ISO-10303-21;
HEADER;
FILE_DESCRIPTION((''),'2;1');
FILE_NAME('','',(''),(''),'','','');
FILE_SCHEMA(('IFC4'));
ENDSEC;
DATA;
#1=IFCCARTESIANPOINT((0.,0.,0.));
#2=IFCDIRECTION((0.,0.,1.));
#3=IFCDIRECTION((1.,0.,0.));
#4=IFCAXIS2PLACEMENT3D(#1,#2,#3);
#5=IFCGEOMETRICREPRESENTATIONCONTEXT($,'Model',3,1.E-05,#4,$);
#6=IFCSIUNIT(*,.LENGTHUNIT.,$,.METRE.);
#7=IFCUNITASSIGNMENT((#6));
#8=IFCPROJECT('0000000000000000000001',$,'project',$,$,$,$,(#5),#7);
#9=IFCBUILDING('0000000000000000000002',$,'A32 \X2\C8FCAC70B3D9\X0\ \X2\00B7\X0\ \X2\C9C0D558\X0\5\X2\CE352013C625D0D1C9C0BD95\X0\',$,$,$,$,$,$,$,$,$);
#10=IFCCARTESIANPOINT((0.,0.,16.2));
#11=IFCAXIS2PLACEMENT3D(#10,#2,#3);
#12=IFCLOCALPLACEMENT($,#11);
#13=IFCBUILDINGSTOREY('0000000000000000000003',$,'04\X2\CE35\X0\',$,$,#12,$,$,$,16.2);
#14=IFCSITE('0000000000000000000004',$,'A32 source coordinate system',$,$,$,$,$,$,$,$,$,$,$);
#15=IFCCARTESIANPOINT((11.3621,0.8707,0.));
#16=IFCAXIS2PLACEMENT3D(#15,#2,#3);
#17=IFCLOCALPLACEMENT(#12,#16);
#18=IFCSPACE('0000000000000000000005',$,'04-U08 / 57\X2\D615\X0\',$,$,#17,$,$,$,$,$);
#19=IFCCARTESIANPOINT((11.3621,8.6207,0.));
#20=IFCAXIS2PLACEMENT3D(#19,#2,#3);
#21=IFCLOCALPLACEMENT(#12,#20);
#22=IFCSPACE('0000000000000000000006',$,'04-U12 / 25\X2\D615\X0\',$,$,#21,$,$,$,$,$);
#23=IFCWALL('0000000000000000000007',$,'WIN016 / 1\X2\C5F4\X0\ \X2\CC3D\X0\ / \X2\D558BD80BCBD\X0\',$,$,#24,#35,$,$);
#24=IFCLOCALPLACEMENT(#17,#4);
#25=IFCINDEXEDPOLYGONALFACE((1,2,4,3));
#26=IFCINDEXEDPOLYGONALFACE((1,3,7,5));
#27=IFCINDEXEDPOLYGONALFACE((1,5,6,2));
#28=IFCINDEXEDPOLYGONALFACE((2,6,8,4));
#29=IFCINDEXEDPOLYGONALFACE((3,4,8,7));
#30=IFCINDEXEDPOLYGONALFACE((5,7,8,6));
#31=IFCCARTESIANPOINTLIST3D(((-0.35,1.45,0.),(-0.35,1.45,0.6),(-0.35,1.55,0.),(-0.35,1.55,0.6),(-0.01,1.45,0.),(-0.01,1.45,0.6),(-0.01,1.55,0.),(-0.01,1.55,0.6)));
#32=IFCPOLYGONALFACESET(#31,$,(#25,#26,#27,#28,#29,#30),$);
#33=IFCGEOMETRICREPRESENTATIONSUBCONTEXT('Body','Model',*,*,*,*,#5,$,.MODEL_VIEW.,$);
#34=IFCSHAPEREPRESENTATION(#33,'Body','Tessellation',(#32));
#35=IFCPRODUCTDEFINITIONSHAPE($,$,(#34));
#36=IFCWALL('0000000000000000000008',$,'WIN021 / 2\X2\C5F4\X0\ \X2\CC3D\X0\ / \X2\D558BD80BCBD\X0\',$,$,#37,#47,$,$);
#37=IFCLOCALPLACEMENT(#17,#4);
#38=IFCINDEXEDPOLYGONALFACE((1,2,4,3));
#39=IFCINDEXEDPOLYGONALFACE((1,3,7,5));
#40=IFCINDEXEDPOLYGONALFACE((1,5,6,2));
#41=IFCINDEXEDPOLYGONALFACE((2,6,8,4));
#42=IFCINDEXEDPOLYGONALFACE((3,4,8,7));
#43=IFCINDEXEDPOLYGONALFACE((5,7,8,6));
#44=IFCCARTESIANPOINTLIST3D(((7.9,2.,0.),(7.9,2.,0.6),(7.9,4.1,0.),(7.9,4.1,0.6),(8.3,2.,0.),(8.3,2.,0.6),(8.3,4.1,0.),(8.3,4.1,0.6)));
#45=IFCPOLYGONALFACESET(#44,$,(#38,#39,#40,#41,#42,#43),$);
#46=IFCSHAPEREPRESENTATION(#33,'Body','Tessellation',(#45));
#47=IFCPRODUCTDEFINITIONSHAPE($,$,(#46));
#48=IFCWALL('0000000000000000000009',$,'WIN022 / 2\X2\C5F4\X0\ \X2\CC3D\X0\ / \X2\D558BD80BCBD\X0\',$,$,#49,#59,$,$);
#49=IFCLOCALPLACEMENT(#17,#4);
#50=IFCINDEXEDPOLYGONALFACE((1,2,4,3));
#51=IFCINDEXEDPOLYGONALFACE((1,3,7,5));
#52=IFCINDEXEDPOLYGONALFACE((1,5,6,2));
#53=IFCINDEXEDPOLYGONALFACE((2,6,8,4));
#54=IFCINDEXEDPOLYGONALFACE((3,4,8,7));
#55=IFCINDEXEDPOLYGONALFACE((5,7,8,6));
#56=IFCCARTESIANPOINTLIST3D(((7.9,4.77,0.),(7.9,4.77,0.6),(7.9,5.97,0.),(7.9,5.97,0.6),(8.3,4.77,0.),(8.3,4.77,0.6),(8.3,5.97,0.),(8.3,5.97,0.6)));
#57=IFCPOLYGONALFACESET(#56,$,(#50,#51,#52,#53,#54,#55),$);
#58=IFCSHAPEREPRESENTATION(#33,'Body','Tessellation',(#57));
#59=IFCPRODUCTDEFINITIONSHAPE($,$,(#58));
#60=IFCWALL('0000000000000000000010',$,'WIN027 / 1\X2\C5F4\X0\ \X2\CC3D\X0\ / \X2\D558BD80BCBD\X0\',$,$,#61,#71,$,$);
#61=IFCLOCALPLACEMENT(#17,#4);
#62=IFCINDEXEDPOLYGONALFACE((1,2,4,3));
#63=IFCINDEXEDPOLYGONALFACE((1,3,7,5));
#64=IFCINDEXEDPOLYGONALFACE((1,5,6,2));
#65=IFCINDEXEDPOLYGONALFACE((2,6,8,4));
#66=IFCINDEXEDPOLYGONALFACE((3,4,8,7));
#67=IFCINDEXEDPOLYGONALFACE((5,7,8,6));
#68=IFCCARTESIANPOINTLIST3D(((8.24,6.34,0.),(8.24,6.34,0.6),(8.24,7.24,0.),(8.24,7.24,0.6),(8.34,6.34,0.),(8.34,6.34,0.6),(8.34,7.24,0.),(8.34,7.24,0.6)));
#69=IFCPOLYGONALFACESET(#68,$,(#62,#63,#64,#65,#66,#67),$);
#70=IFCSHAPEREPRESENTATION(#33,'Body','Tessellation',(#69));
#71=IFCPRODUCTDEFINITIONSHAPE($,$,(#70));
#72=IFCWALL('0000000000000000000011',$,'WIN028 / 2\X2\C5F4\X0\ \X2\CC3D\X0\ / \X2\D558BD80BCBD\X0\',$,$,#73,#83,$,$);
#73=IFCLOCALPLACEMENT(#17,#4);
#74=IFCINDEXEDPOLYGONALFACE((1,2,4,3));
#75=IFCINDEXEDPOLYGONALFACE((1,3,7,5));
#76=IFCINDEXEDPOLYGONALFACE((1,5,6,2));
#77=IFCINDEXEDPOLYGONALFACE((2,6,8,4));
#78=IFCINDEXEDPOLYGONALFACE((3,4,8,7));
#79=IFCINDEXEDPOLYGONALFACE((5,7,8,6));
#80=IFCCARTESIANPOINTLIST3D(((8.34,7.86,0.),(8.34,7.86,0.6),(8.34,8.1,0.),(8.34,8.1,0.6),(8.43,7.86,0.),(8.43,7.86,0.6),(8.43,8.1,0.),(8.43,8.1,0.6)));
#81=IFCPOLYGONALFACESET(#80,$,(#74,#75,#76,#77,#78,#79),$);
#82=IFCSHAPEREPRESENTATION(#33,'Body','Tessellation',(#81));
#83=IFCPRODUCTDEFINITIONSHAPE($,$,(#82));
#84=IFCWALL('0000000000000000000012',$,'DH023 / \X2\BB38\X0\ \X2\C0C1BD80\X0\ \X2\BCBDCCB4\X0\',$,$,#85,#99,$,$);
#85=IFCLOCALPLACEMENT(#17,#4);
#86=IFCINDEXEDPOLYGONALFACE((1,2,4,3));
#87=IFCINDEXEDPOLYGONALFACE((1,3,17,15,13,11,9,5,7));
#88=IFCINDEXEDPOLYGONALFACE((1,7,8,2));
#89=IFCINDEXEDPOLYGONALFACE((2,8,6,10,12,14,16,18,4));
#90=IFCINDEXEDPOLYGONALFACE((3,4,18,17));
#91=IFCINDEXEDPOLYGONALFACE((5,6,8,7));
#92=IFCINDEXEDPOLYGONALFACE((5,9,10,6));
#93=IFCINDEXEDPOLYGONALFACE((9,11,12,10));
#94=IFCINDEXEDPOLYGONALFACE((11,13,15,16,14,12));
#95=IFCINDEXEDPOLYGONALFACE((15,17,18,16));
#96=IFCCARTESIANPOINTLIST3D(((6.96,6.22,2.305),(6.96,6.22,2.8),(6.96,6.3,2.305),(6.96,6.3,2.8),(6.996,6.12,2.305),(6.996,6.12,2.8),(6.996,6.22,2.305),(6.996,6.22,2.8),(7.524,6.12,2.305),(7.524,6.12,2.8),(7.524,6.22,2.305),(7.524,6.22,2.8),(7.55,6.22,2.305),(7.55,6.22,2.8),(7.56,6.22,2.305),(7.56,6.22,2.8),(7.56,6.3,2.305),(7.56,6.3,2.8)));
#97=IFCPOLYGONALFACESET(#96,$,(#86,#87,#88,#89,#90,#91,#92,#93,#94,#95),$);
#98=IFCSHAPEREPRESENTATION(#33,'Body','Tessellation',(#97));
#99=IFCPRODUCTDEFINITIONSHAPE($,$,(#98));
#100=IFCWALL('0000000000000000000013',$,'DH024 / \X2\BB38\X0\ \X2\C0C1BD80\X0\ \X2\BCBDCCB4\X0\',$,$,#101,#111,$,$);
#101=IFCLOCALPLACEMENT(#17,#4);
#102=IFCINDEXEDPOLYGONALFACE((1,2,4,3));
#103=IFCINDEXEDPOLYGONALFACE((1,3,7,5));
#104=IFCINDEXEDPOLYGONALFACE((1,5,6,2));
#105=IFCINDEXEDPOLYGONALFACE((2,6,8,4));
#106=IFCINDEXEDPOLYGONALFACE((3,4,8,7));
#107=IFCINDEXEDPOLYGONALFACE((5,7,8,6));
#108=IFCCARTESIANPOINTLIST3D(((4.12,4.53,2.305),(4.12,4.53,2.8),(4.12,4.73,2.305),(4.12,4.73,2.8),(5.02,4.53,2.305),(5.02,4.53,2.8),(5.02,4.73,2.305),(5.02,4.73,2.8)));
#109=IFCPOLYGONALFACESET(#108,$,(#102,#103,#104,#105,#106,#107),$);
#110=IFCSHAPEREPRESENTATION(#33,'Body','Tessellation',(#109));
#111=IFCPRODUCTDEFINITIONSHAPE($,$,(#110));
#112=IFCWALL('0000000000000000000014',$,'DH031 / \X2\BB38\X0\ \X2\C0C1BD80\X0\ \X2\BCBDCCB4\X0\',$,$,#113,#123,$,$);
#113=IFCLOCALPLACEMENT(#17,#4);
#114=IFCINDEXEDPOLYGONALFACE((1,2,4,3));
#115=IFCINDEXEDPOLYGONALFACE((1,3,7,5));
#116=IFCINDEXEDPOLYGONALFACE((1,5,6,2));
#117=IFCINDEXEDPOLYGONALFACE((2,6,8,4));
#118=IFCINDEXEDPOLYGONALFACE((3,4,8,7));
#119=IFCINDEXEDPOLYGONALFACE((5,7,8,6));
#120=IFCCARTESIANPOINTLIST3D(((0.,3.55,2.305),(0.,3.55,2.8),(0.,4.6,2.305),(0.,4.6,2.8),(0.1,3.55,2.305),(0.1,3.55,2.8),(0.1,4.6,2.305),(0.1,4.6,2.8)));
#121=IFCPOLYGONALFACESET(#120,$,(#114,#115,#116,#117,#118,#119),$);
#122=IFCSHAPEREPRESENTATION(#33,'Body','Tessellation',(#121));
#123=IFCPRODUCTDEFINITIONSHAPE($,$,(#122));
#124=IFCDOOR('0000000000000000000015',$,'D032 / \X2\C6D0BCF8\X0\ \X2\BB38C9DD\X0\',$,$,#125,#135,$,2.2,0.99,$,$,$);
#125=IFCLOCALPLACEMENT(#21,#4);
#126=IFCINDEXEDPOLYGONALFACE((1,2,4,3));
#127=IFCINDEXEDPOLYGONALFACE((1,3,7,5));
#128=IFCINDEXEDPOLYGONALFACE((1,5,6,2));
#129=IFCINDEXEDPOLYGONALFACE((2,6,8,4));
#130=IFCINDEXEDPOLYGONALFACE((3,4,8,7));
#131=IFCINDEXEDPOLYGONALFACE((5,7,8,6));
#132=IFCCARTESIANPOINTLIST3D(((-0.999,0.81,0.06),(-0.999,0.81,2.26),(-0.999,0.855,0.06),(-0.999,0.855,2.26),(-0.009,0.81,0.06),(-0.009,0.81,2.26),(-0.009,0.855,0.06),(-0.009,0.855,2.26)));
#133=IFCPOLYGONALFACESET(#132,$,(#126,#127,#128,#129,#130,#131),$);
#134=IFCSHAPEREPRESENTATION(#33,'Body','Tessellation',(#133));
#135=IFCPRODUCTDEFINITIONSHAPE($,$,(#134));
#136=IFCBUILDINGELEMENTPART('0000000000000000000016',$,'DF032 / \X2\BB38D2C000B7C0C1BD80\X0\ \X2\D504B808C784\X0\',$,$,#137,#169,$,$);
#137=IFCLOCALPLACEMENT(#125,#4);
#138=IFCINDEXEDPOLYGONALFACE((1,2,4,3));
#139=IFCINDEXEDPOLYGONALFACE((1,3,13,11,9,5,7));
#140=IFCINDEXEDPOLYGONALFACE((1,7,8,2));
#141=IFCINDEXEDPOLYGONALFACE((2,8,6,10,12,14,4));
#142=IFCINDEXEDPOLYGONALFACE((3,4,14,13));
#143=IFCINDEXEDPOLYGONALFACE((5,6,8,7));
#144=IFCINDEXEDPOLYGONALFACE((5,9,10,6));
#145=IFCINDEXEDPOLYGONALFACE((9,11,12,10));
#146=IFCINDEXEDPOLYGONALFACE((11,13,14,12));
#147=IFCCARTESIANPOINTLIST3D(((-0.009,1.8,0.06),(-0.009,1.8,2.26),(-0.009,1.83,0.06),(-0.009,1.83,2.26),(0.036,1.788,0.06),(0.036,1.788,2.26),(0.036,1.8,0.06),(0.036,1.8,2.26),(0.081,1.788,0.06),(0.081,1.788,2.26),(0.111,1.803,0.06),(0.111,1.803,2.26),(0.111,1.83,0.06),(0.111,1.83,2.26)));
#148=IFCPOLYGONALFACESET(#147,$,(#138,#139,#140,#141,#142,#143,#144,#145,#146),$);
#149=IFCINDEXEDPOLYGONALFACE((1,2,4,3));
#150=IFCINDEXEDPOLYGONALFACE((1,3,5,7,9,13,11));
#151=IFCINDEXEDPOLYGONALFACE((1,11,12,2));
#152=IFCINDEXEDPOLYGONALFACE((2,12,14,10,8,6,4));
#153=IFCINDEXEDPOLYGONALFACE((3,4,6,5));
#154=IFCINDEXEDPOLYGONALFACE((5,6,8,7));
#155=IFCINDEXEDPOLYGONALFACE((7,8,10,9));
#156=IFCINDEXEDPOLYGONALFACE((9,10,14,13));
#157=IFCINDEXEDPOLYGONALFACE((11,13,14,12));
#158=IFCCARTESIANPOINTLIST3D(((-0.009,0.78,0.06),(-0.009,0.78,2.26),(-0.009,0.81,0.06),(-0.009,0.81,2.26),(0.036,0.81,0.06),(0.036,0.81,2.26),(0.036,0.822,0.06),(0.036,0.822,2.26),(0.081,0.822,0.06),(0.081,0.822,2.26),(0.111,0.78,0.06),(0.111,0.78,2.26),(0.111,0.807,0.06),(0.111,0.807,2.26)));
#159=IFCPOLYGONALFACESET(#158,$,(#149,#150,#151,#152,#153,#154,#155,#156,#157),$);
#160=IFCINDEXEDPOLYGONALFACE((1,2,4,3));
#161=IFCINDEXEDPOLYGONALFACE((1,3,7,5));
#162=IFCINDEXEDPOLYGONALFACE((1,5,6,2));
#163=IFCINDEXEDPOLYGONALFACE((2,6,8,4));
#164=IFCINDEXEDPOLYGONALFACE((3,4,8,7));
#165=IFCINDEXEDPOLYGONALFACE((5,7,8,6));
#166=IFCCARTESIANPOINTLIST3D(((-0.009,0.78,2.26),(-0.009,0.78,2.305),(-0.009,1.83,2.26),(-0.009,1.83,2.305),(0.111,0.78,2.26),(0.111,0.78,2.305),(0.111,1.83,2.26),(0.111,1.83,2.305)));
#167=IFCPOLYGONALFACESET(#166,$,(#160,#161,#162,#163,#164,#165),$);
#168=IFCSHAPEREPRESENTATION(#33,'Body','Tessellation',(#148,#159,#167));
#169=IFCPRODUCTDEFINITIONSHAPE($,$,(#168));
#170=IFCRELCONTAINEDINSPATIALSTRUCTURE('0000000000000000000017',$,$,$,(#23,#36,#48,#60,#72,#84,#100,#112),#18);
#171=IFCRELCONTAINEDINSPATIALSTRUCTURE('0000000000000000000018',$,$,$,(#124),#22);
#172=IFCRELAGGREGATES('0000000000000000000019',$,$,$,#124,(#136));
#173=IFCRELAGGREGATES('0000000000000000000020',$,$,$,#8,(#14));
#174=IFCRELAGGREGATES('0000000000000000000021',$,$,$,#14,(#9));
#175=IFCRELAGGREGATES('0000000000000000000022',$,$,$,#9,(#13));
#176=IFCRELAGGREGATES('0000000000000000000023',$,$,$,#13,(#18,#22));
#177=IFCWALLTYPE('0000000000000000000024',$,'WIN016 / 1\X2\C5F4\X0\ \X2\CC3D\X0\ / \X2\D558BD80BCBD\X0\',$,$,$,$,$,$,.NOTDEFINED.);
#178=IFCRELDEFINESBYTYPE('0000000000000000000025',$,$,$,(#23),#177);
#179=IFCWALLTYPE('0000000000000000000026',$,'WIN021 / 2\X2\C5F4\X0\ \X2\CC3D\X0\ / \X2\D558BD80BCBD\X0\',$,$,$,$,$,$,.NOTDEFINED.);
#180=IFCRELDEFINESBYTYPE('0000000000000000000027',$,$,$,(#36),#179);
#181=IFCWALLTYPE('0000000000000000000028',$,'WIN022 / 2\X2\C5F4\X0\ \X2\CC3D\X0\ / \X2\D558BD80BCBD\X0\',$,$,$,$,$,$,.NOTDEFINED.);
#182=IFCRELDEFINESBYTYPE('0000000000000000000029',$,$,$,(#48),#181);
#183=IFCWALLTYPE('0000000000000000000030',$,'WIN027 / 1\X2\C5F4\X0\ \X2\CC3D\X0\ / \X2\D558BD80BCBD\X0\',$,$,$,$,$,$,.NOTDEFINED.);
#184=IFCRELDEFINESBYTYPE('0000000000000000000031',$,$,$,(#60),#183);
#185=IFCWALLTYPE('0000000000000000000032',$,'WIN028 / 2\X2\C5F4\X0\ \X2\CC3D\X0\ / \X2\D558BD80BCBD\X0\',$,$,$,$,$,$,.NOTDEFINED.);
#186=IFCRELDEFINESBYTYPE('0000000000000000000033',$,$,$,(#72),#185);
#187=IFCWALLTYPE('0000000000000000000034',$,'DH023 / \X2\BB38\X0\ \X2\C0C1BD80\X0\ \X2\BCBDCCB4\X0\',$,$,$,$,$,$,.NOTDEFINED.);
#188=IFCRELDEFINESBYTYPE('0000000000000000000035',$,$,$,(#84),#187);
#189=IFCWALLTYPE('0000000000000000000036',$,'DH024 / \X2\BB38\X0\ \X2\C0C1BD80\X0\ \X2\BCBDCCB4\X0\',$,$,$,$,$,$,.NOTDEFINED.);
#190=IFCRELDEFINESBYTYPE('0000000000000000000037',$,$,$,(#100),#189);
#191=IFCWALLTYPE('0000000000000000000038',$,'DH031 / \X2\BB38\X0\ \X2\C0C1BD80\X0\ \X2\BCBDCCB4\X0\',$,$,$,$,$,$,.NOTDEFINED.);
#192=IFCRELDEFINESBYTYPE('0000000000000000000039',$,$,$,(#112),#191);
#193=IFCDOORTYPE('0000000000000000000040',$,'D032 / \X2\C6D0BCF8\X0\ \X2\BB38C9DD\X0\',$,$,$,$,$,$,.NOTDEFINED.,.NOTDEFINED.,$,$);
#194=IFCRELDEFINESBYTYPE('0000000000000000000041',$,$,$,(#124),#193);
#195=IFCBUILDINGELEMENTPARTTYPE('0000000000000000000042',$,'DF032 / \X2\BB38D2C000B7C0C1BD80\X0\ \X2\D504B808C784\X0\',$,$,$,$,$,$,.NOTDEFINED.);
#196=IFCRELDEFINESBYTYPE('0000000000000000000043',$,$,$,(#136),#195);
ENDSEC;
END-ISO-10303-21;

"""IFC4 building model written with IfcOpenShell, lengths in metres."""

from ifc_helpers import new_model, si_unit, frame, origin, origin_with_axes, place, context, subcontext, project, spatial, polyline, outline, extrude, source, transform, mapped, type_object, type_shapes, element, aggregate, save


model = new_model("IFC4")

# Units and contexts
model_context = context("Model", 3, precision=1e-05, world=origin_with_axes())
body_context = subcontext(model_context, "Body", "Model", "MODEL_VIEW")
ifc_project = project(units=[si_unit("LENGTHUNIT", "METRE")], contexts=[model_context])

# Site, building, storey, space
site = spatial("IfcSite", under=ifc_project, Name="A32 source coordinate system")
building = spatial("IfcBuilding", under=site, Name="A32 주거동 · 지하5층–옥탑지붕")
storey_placement = place(None, frame((0.0, 0.0, 16.2), z_axis=(0.0, 0.0, 1.0), x_axis=(1.0, 0.0, 0.0)))
storey = spatial("IfcBuildingStorey", under=building, at=storey_placement, Name="04층", Elevation=16.2)
space_1_placement = place(storey_placement, frame((11.3621, 0.8707, 0.0), z_axis=(0.0, 0.0, 1.0), x_axis=(1.0, 0.0, 0.0)))
space_1 = spatial("IfcSpace", under=storey, at=space_1_placement, Name="04-U08 / 57형")

# Walls
wall_type_1 = type_object("IfcWallType", Name="WIN016 / 1열 창 / 하부벽", PredefinedType="NOTDEFINED")
shared_shape_1 = source(origin(), body_context, "Body", "SweptSolid", [
    extrude(outline(polyline([(-0.35, 1.45), (-0.35, 1.55), (-0.01, 1.55), (-0.01, 1.45), (-0.35, 1.45)])), origin(), (0.0, 0.0, 1.0), 0.6),
])
type_shapes(wall_type_1, [shared_shape_1])
wall_1_placement = place(space_1_placement, origin_with_axes())
element("IfcWall", 1, at=wall_1_placement, inside=space_1, type_object=wall_type_1, Name="WIN016 / 1열 창 / 하부벽", context=body_context, shape_type="MappedRepresentation", body=[
    mapped(shared_shape_1, transform((0.0, 0.0, 0.0), scale=1.0)),
])
wall_type_2 = type_object("IfcWallType", Name="WIN021 / 2열 창 / 하부벽", PredefinedType="NOTDEFINED")
shared_shape_2 = source(origin(), body_context, "Body", "SweptSolid", [
    extrude(outline(polyline([(7.9, 2.0), (7.9, 4.1), (8.3, 4.1), (8.3, 2.0), (7.9, 2.0)])), origin(), (0.0, 0.0, 1.0), 0.6),
])
type_shapes(wall_type_2, [shared_shape_2])
wall_2_placement = place(space_1_placement, origin_with_axes())
element("IfcWall", 2, at=wall_2_placement, inside=space_1, type_object=wall_type_2, Name="WIN021 / 2열 창 / 하부벽", context=body_context, shape_type="MappedRepresentation", body=[
    mapped(shared_shape_2, transform((0.0, 0.0, 0.0), scale=1.0)),
])
wall_type_3 = type_object("IfcWallType", Name="WIN022 / 2열 창 / 하부벽", PredefinedType="NOTDEFINED")
shared_shape_3 = source(origin(), body_context, "Body", "SweptSolid", [
    extrude(outline(polyline([(7.9, 4.77), (7.9, 5.97), (8.3, 5.97), (8.3, 4.77), (7.9, 4.77)])), origin(), (0.0, 0.0, 1.0), 0.6),
])
type_shapes(wall_type_3, [shared_shape_3])
wall_3_placement = place(space_1_placement, origin_with_axes())
element("IfcWall", 3, at=wall_3_placement, inside=space_1, type_object=wall_type_3, Name="WIN022 / 2열 창 / 하부벽", context=body_context, shape_type="MappedRepresentation", body=[
    mapped(shared_shape_3, transform((0.0, 0.0, 0.0), scale=1.0)),
])
wall_type_4 = type_object("IfcWallType", Name="WIN027 / 1열 창 / 하부벽", PredefinedType="NOTDEFINED")
shared_shape_4 = source(origin(), body_context, "Body", "SweptSolid", [
    extrude(outline(polyline([(8.24, 6.34), (8.24, 7.24), (8.34, 7.24), (8.34, 6.34), (8.24, 6.34)])), origin(), (0.0, 0.0, 1.0), 0.6),
])
type_shapes(wall_type_4, [shared_shape_4])
wall_4_placement = place(space_1_placement, origin_with_axes())
element("IfcWall", 4, at=wall_4_placement, inside=space_1, type_object=wall_type_4, Name="WIN027 / 1열 창 / 하부벽", context=body_context, shape_type="MappedRepresentation", body=[
    mapped(shared_shape_4, transform((0.0, 0.0, 0.0), scale=1.0)),
])
wall_type_5 = type_object("IfcWallType", Name="WIN028 / 2열 창 / 하부벽", PredefinedType="NOTDEFINED")
shared_shape_5 = source(origin(), body_context, "Body", "SweptSolid", [
    extrude(outline(polyline([(8.34, 7.86), (8.34, 8.1), (8.43, 8.1), (8.43, 7.86), (8.34, 7.86)])), origin(), (0.0, 0.0, 1.0), 0.6),
])
type_shapes(wall_type_5, [shared_shape_5])
wall_5_placement = place(space_1_placement, origin_with_axes())
element("IfcWall", 5, at=wall_5_placement, inside=space_1, type_object=wall_type_5, Name="WIN028 / 2열 창 / 하부벽", context=body_context, shape_type="MappedRepresentation", body=[
    mapped(shared_shape_5, transform((0.0, 0.0, 0.0), scale=1.0)),
])
wall_type_6 = type_object("IfcWallType", Name="DH023 / 문 상부 벽체", PredefinedType="NOTDEFINED")
shared_shape_6 = source(origin(), body_context, "Body", "SweptSolid", [
    extrude(outline(polyline([(6.96, 6.3), (7.56, 6.3), (7.56, 6.22), (7.55, 6.22), (7.524, 6.22), (7.524, 6.12), (6.996, 6.12), (6.996, 6.22), (6.96, 6.22), (6.96, 6.3)])), frame((0.0, 0.0, 2.305)), (0.0, 0.0, 1.0), 0.495),
])
type_shapes(wall_type_6, [shared_shape_6])
wall_6_placement = place(space_1_placement, origin_with_axes())
element("IfcWall", 6, at=wall_6_placement, inside=space_1, type_object=wall_type_6, Name="DH023 / 문 상부 벽체", context=body_context, shape_type="MappedRepresentation", body=[
    mapped(shared_shape_6, transform((0.0, 0.0, 0.0), scale=1.0)),
])
wall_type_7 = type_object("IfcWallType", Name="DH024 / 문 상부 벽체", PredefinedType="NOTDEFINED")
shared_shape_7 = source(origin(), body_context, "Body", "SweptSolid", [
    extrude(outline(polyline([(4.12, 4.73), (5.02, 4.73), (5.02, 4.53), (4.12, 4.53), (4.12, 4.73)])), frame((0.0, 0.0, 2.305)), (0.0, 0.0, 1.0), 0.495),
])
type_shapes(wall_type_7, [shared_shape_7])
wall_7_placement = place(space_1_placement, origin_with_axes())
element("IfcWall", 7, at=wall_7_placement, inside=space_1, type_object=wall_type_7, Name="DH024 / 문 상부 벽체", context=body_context, shape_type="MappedRepresentation", body=[
    mapped(shared_shape_7, transform((0.0, 0.0, 0.0), scale=1.0)),
])
wall_type_8 = type_object("IfcWallType", Name="DH031 / 문 상부 벽체", PredefinedType="NOTDEFINED")
shared_shape_8 = source(origin(), body_context, "Body", "SweptSolid", [
    extrude(outline(polyline([(0.0, 4.6), (0.1, 4.6), (0.1, 3.55), (0.0, 3.55), (0.0, 4.6)])), frame((0.0, 0.0, 2.305)), (0.0, 0.0, 1.0), 0.495),
])
type_shapes(wall_type_8, [shared_shape_8])
wall_8_placement = place(space_1_placement, origin_with_axes())
element("IfcWall", 8, at=wall_8_placement, inside=space_1, type_object=wall_type_8, Name="DH031 / 문 상부 벽체", context=body_context, shape_type="MappedRepresentation", body=[
    mapped(shared_shape_8, transform((0.0, 0.0, 0.0), scale=1.0)),
])

# Shared definitions
space_2_placement = place(storey_placement, frame((11.3621, 8.6207, 0.0), z_axis=(0.0, 0.0, 1.0), x_axis=(1.0, 0.0, 0.0)))
space_2 = spatial("IfcSpace", under=storey, at=space_2_placement, Name="04-U12 / 25형")

# Door
door_type = type_object("IfcDoorType", Name="D032 / 원본 문짝", OperationType="NOTDEFINED", PredefinedType="NOTDEFINED")
shared_shape_9 = source(origin(), body_context, "Body", "SweptSolid", [
    extrude(outline(polyline([(-0.009, 0.81), (-0.999, 0.81), (-0.999, 0.855), (-0.009, 0.855), (-0.009, 0.81)])), frame((0.0, 0.0, 0.06)), (0.0, 0.0, 1.0), 2.2),
])
type_shapes(door_type, [shared_shape_9])
door_placement = place(space_2_placement, origin_with_axes())
door = element("IfcDoor", 9, at=door_placement, inside=space_2, type_object=door_type, Name="D032 / 원본 문짝", OverallHeight=2.2, OverallWidth=0.99, context=body_context, shape_type="MappedRepresentation", body=[
    mapped(shared_shape_9, transform((0.0, 0.0, 0.0), scale=1.0)),
])

# Building element part
building_element_part_type = type_object("IfcBuildingElementPartType", Name="DF032 / 문틀·상부 프레임", PredefinedType="NOTDEFINED")
shared_shape_10 = source(origin(), body_context, "Body", "SweptSolid", [
    extrude(outline(polyline([(0.111, 1.83), (0.111, 1.803), (0.081, 1.788), (0.036, 1.788), (0.036, 1.8), (-0.009, 1.8), (-0.009, 1.83), (0.111, 1.83)])), frame((0.0, 0.0, 0.06)), (0.0, 0.0, 1.0), 2.2),
    extrude(outline(polyline([(-0.009, 0.81), (0.036, 0.81), (0.036, 0.822), (0.081, 0.822), (0.111, 0.807), (0.111, 0.78), (-0.009, 0.78), (-0.009, 0.81)])), frame((0.0, 0.0, 0.06)), (0.0, 0.0, 1.0), 2.2),
    extrude(outline(polyline([(-0.009, 0.78), (-0.009, 1.83), (0.111, 1.83), (0.111, 0.78), (-0.009, 0.78)])), frame((0.0, 0.0, 2.26)), (0.0, 0.0, 1.0), 0.045),
])
type_shapes(building_element_part_type, [shared_shape_10])
building_element_part_placement = place(door_placement, origin_with_axes())
building_element_part = element("IfcBuildingElementPart", 10, at=building_element_part_placement, type_object=building_element_part_type, Name="DF032 / 문틀·상부 프레임", context=body_context, shape_type="MappedRepresentation", body=[
    mapped(shared_shape_10, transform((0.0, 0.0, 0.0), scale=1.0)),
])
aggregate(door, [building_element_part])

save(model, "model.ifc")
